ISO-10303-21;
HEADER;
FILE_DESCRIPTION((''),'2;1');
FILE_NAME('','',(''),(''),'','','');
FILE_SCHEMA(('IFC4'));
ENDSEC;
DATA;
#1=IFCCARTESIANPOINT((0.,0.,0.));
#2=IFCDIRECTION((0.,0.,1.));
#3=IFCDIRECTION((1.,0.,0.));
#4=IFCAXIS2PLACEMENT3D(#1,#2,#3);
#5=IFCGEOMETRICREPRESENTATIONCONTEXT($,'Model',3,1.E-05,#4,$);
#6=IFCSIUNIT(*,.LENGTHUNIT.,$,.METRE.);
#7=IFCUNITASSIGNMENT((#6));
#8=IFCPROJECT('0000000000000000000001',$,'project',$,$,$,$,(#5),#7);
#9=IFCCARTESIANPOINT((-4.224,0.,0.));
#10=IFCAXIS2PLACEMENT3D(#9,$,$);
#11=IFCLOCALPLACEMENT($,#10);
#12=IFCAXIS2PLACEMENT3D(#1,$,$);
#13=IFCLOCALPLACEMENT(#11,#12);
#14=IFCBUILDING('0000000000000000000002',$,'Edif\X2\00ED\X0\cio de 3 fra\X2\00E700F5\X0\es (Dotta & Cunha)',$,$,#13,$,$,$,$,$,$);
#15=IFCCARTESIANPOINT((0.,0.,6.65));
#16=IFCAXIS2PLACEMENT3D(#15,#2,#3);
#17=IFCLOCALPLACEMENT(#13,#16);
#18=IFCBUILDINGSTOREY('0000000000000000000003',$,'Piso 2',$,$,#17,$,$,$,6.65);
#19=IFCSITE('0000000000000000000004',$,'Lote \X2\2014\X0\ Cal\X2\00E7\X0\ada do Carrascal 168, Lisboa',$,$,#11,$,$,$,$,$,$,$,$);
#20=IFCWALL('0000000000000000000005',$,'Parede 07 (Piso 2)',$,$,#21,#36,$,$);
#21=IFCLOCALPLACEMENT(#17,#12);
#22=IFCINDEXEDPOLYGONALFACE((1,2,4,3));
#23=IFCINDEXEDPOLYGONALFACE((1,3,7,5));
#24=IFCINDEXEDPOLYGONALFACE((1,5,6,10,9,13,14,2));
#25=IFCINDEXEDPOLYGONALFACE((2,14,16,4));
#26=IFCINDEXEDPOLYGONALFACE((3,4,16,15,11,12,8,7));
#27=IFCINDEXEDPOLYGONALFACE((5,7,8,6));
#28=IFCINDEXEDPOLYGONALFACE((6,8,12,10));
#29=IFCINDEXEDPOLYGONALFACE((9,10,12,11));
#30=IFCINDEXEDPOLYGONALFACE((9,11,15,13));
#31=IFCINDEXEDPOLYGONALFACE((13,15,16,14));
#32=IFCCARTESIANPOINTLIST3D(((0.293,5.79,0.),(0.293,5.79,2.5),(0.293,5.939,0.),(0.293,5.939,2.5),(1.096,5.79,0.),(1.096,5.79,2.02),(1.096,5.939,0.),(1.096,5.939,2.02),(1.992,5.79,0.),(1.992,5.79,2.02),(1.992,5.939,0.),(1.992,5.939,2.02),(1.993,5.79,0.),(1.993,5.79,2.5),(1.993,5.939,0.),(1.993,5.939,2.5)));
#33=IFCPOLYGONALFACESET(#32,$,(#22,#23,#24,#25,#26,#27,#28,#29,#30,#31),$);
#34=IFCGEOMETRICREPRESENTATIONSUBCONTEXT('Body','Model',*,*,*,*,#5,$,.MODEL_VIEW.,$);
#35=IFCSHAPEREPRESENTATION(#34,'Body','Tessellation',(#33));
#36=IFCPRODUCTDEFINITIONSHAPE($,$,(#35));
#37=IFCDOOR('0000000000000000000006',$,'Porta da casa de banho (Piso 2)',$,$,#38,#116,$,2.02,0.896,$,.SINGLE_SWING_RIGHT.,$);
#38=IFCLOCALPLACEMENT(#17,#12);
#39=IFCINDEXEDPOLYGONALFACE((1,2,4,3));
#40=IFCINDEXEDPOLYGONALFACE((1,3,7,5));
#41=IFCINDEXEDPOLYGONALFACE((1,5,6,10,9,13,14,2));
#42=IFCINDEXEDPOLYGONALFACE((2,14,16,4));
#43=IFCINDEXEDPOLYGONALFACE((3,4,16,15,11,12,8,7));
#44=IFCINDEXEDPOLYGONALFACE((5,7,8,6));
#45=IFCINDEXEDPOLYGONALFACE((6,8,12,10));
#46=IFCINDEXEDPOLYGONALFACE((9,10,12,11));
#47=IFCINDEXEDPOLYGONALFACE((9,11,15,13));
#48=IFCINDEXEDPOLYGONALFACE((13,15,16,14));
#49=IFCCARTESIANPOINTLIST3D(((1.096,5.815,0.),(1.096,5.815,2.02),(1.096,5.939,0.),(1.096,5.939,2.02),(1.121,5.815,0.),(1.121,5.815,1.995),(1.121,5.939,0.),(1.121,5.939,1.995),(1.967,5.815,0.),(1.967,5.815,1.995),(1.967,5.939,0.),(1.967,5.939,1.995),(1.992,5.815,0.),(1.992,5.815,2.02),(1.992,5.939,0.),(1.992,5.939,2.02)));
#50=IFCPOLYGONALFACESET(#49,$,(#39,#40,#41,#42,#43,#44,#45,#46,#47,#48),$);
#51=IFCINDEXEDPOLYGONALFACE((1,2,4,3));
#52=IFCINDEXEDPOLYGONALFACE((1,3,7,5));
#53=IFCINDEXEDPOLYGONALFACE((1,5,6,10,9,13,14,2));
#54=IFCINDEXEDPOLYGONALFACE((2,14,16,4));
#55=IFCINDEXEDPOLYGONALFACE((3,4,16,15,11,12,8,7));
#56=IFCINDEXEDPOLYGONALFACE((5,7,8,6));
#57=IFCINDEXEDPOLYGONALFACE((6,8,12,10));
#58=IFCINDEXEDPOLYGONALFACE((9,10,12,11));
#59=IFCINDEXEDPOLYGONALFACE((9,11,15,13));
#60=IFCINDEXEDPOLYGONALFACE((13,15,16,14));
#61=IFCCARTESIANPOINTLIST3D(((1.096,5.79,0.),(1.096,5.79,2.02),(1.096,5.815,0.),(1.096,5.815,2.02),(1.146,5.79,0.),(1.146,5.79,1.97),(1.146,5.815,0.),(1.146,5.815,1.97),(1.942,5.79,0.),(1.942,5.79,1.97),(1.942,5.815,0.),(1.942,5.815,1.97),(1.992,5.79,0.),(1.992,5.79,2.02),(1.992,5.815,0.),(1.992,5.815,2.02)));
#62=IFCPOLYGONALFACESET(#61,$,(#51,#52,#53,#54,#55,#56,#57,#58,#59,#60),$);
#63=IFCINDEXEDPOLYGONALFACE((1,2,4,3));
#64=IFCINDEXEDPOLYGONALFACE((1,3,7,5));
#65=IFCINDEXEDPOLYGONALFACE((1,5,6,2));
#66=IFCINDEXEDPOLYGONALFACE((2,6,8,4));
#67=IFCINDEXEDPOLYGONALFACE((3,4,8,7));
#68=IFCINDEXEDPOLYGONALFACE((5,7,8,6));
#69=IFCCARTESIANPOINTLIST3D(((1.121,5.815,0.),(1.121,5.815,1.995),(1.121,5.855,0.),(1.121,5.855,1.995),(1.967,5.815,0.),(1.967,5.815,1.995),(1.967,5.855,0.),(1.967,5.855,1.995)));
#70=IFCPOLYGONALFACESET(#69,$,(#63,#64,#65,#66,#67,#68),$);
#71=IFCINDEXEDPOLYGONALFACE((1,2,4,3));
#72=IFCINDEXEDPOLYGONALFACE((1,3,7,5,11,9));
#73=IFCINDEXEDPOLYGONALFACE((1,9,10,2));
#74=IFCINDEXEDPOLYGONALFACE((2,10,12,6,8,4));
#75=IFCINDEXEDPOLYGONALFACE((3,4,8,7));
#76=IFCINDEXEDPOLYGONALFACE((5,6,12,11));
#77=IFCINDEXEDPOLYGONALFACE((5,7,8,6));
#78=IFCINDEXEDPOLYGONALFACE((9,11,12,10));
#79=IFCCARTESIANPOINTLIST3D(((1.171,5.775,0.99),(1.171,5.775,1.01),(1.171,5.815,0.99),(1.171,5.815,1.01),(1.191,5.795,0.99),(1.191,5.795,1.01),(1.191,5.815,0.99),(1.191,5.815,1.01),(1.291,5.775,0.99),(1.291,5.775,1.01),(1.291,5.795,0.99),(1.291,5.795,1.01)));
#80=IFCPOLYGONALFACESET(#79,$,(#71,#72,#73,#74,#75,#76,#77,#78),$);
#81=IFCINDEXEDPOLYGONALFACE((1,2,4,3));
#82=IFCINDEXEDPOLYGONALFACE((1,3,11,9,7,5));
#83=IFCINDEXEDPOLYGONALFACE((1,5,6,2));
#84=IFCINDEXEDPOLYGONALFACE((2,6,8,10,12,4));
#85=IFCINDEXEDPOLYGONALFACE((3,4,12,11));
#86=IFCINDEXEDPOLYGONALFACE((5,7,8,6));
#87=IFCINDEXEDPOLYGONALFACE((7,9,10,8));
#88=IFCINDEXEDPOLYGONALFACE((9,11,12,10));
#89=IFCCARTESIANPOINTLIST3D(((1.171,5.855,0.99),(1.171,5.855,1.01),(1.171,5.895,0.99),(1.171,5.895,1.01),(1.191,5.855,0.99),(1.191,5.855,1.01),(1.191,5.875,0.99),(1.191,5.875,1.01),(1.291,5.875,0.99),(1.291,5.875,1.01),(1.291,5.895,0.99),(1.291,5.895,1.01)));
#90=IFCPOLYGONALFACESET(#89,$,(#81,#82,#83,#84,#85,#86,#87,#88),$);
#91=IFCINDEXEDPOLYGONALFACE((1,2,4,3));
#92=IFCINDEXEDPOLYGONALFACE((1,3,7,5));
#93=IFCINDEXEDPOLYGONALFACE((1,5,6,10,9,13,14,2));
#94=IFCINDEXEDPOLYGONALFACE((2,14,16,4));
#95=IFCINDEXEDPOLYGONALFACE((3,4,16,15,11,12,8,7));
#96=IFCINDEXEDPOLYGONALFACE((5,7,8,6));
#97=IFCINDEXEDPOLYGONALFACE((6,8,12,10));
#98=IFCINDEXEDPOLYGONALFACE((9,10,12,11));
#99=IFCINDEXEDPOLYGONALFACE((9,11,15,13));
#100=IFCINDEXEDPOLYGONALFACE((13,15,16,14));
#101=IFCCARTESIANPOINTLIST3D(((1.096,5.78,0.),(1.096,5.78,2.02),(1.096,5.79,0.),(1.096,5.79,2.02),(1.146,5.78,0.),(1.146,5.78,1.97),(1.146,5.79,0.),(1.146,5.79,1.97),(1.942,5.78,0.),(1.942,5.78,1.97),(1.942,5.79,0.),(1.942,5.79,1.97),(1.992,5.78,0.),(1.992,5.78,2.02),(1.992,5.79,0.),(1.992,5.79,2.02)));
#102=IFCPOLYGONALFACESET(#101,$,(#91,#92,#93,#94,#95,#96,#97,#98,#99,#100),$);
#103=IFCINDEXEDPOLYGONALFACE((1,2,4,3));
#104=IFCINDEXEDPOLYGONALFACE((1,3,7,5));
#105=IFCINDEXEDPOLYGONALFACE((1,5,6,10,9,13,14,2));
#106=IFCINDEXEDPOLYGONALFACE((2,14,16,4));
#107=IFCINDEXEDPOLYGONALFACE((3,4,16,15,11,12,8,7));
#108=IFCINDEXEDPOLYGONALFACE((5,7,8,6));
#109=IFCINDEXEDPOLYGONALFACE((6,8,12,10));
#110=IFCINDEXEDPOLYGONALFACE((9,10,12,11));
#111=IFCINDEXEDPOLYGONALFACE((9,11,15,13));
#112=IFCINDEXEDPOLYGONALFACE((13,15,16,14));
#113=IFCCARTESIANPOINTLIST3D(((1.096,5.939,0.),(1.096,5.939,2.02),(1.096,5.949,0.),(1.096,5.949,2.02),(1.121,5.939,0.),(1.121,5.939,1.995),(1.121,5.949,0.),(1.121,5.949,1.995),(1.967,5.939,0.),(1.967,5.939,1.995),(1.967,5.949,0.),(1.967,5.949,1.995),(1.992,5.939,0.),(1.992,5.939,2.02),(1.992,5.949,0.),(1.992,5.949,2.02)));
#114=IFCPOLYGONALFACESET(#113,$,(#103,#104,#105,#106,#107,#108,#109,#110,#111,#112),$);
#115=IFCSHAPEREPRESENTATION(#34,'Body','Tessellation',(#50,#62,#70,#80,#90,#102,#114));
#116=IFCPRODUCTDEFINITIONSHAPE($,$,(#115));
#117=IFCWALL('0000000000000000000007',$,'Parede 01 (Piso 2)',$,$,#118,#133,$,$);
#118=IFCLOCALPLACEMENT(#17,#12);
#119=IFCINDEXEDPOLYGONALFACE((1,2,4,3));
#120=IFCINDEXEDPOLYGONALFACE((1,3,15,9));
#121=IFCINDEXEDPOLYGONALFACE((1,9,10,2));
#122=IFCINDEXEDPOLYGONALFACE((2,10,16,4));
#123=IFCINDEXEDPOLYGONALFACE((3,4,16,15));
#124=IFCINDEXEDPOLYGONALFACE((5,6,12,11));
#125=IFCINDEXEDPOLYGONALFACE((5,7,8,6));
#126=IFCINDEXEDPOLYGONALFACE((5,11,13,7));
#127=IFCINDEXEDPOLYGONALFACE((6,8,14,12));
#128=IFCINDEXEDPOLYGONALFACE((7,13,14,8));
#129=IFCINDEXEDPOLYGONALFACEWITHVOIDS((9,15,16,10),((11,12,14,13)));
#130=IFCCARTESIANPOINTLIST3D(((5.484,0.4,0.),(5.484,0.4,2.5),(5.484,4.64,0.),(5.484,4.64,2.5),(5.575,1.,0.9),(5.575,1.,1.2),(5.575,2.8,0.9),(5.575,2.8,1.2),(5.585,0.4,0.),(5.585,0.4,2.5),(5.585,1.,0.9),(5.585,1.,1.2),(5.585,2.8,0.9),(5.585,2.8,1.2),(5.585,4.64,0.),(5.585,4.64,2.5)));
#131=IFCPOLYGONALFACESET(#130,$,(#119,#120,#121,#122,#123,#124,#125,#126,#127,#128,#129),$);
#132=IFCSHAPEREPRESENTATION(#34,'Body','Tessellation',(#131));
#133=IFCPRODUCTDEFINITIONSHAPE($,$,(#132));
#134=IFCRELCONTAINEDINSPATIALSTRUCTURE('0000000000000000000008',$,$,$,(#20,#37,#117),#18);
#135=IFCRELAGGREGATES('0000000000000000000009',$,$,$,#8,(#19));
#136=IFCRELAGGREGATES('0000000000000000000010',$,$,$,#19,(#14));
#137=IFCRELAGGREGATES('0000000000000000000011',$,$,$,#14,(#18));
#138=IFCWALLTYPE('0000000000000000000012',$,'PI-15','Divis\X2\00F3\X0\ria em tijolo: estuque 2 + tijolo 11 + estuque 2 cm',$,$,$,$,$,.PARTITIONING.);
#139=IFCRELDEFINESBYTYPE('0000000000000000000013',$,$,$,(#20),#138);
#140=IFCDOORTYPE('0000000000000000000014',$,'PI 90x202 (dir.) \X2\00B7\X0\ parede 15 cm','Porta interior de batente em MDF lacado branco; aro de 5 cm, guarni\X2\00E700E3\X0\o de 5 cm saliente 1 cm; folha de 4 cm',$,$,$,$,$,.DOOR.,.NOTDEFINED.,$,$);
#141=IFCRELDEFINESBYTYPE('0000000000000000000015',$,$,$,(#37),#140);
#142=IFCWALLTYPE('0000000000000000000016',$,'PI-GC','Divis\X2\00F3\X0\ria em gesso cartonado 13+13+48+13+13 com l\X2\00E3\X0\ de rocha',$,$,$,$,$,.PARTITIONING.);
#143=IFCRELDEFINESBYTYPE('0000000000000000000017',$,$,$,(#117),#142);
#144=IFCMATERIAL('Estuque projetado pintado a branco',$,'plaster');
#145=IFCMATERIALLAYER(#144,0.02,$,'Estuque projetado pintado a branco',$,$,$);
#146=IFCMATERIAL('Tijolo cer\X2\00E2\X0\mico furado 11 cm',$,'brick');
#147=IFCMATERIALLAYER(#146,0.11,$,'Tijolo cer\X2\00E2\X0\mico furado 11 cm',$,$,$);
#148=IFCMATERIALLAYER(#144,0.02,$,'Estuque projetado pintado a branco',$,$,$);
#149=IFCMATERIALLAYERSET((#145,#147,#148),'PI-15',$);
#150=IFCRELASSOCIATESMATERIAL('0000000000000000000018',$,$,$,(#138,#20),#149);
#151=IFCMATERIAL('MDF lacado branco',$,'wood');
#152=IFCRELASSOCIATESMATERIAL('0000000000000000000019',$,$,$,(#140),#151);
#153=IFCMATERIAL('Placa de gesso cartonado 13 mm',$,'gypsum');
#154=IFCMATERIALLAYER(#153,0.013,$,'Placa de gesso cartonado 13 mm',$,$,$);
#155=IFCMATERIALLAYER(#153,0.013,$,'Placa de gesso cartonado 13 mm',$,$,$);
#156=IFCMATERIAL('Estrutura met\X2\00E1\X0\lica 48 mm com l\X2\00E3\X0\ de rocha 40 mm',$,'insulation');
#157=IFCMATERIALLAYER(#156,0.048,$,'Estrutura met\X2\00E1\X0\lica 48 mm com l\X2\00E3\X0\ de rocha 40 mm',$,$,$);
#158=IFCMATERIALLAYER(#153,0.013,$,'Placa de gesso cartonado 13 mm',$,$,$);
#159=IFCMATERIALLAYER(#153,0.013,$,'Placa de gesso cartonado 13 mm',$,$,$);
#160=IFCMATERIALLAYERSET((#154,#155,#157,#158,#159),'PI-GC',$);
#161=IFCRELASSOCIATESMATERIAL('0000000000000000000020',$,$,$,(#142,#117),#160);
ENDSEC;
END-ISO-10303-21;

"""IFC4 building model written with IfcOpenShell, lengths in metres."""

from ifc_helpers import new_model, si_unit, frame, origin, origin_with_axes, place, context, subcontext, project, spatial, line, indexed_curve, outline, extrude, source, transform, mapped, material, layer, layer_set, layer_usage, type_object, type_shapes, element, fill, save


model = new_model("IFC4")

# Units and contexts
model_context = context("Model", 3, precision=1e-05, world=origin_with_axes())
body_context = subcontext(model_context, "Body", "Model", "MODEL_VIEW")
ifc_project = project(units=[si_unit("LENGTHUNIT", "METRE")], contexts=[model_context])

# Site, building, storey
site_placement = place(None, frame((-4.224, 0.0, 0.0)))
site = spatial("IfcSite", under=ifc_project, at=site_placement, Name="Lote — Calçada do Carrascal 168, Lisboa")
building_placement = place(site_placement, origin())
building = spatial("IfcBuilding", under=site, at=building_placement, Name="Edifício de 3 frações (Dotta & Cunha)")
storey_placement = place(building_placement, frame((0.0, 0.0, 6.65), z_axis=(0.0, 0.0, 1.0), x_axis=(1.0, 0.0, 0.0)))
storey = spatial("IfcBuildingStorey", under=building, at=storey_placement, Name="Piso 2", Elevation=6.65)

# Shared definitions
ifc_material_1 = material(Name="Estuque projetado pintado a branco", Category="plaster")
ifc_layer_1 = layer(ifc_material_1, 0.02, Name="Estuque projetado pintado a branco")
ifc_material_2 = material(Name="Tijolo cerâmico furado 11 cm", Category="brick")
ifc_layer_2 = layer(ifc_material_2, 0.11, Name="Tijolo cerâmico furado 11 cm")
ifc_layer_3 = layer(ifc_material_1, 0.02, Name="Estuque projetado pintado a branco")
ifc_layer_set_1 = layer_set([ifc_layer_1, ifc_layer_2, ifc_layer_3], Name="PI-15")
wall_type_1 = type_object("IfcWallType", Name="PI-15", Description="Divisória em tijolo: estuque 2 + tijolo 11 + estuque 2 cm", PredefinedType="PARTITIONING", material=ifc_layer_set_1)

# Shared definitions
ifc_material_3 = material(Name="MDF lacado branco", Category="wood")

# Wall, opening, door
ifc_layer_usage_1 = layer_usage(ifc_layer_set_1, "AXIS2", "POSITIVE", 0.0)
wall_1_placement = place(storey_placement, origin_with_axes())
wall_1 = element("IfcWall", 1, at=wall_1_placement, inside=storey, type_object=wall_type_1, material=ifc_layer_usage_1, Name="Parede 07 (Piso 2)", context=body_context, shape_type="SweptSolid", body=[
    extrude(outline(indexed_curve([(1.993, 5.79), (1.993, 5.939), (0.293, 5.939), (0.293, 5.79)], segments=[line(1, 2, 3, 4, 1)])), origin_with_axes(), (0.0, 0.0, 1.0), 2.5),
])
opening_1_placement = place(wall_1_placement, origin_with_axes())
opening_1 = element("IfcOpeningElement", 2, at=opening_1_placement, cuts=wall_1, context=body_context, shape_type="SweptSolid", body=[
    extrude(outline(indexed_curve([(1.992, 5.788), (1.992, 5.941), (1.096, 5.941), (1.096, 5.788)], segments=[line(1, 2, 3, 4, 1)])), origin_with_axes(), (0.0, 0.0, 1.0), 2.02),
])
door_type_1 = type_object("IfcDoorType", Name="PI 90x202 (dir.) · parede 15 cm", Description="Porta interior de batente em MDF lacado branco; aro de 5 cm, guarnição de 5 cm saliente 1 cm; folha de 4 cm", OperationType="NOTDEFINED", PredefinedType="DOOR", material=ifc_material_3)
shared_shape_1 = source(origin_with_axes(), body_context, "Body", "SweptSolid", [
    extrude(outline(indexed_curve([(0.0, 0.0), (0.0, 2.02), (0.896, 2.02), (0.896, 0.0), (0.871, 0.0), (0.871, 1.995), (0.025, 1.995), (0.025, 0.0)], segments=[line(1, 2, 3, 4, 5, 6, 7, 8, 1)])), frame((0.0, 0.025, 0.0), z_axis=(0.0, -1.0, 0.0), x_axis=(1.0, 0.0, 0.0)), (0.0, 0.0, -1.0), 0.124),
    extrude(outline(indexed_curve([(0.0, 0.0), (0.0, 2.02), (0.896, 2.02), (0.896, 0.0), (0.846, 0.0), (0.846, 1.97), (0.05, 1.97), (0.05, 0.0)], segments=[line(1, 2, 3, 4, 5, 6, 7, 8, 1)])), frame((0.0, 0.0, 0.0), z_axis=(0.0, -1.0, 0.0), x_axis=(1.0, 0.0, 0.0)), (0.0, 0.0, -1.0), 0.025),
    extrude(outline(indexed_curve([(0.0, 0.0), (0.846, 0.0), (0.846, 0.04), (0.0, 0.04)], segments=[line(1, 2, 3, 4, 1)])), frame((0.025, 0.025, 0.0), z_axis=(0.0, 0.0, 1.0), x_axis=(1.0, 0.0, 0.0)), (0.0, 0.0, 1.0), 1.995),
    extrude(outline(indexed_curve([(0.0, 0.0), (0.0, -0.04), (0.12, -0.04), (0.12, -0.02), (0.02, -0.02), (0.02, 0.0)], segments=[line(1, 2, 3, 4, 5, 6, 1)])), frame((0.075, 0.025, 0.99), z_axis=(0.0, 0.0, 1.0), x_axis=(1.0, 0.0, 0.0)), (0.0, 0.0, 1.0), 0.02),
    extrude(outline(indexed_curve([(0.0, 0.0), (0.0, 0.04), (0.12, 0.04), (0.12, 0.02), (0.02, 0.02), (0.02, 0.0)], segments=[line(1, 2, 3, 4, 5, 6, 1)])), frame((0.075, 0.065, 0.99), z_axis=(0.0, 0.0, 1.0), x_axis=(1.0, 0.0, 0.0)), (0.0, 0.0, 1.0), 0.02),
    extrude(outline(indexed_curve([(0.0, 0.0), (0.0, 2.02), (0.896, 2.02), (0.896, 0.0), (0.846, 0.0), (0.846, 1.97), (0.05, 1.97), (0.05, 0.0)], segments=[line(1, 2, 3, 4, 5, 6, 7, 8, 1)])), frame((0.0, -0.01, 0.0), z_axis=(0.0, -1.0, 0.0), x_axis=(1.0, 0.0, 0.0)), (0.0, 0.0, -1.0), 0.01),
    extrude(outline(indexed_curve([(0.0, 0.0), (0.0, 2.02), (0.896, 2.02), (0.896, 0.0), (0.871, 0.0), (0.871, 1.995), (0.025, 1.995), (0.025, 0.0)], segments=[line(1, 2, 3, 4, 5, 6, 7, 8, 1)])), frame((0.0, 0.149, 0.0), z_axis=(0.0, -1.0, 0.0), x_axis=(1.0, 0.0, 0.0)), (0.0, 0.0, -1.0), 0.01),
])
type_shapes(door_type_1, [shared_shape_1])
door_1_placement = place(storey_placement, frame((1.096, 5.79, 0.0), z_axis=(0.0, 0.0, 1.0), x_axis=(1.0, 0.0, 0.0)))
door_1 = element("IfcDoor", 3, at=door_1_placement, inside=storey, type_object=door_type_1, Name="Porta da casa de banho (Piso 2)", OperationType="SINGLE_SWING_RIGHT", OverallHeight=2.02, OverallWidth=0.896, context=body_context, shape_type="MappedRepresentation", body=[
    mapped(shared_shape_1, transform((0.0, 0.0, 0.0), x_axis=(1.0, 0.0, 0.0), y_axis=(0.0, 1.0, 0.0), z_axis=(0.0, 0.0, 1.0), scale=1.0)),
])
fill(opening_1, door_1)

# Wall, opening
ifc_material_4 = material(Name="Placa de gesso cartonado 13 mm", Category="gypsum")
ifc_layer_4 = layer(ifc_material_4, 0.013, Name="Placa de gesso cartonado 13 mm")
ifc_layer_5 = layer(ifc_material_4, 0.013, Name="Placa de gesso cartonado 13 mm")
ifc_material_5 = material(Name="Estrutura metálica 48 mm com lã de rocha 40 mm", Category="insulation")
ifc_layer_6 = layer(ifc_material_5, 0.048, Name="Estrutura metálica 48 mm com lã de rocha 40 mm")
ifc_layer_7 = layer(ifc_material_4, 0.013, Name="Placa de gesso cartonado 13 mm")
ifc_layer_8 = layer(ifc_material_4, 0.013, Name="Placa de gesso cartonado 13 mm")
ifc_layer_set_2 = layer_set([ifc_layer_4, ifc_layer_5, ifc_layer_6, ifc_layer_7, ifc_layer_8], Name="PI-GC")
ifc_layer_usage_2 = layer_usage(ifc_layer_set_2, "AXIS2", "POSITIVE", 0.0)
wall_type_2 = type_object("IfcWallType", Name="PI-GC", Description="Divisória em gesso cartonado 13+13+48+13+13 com lã de rocha", PredefinedType="PARTITIONING", material=ifc_layer_set_2)
wall_2_placement = place(storey_placement, origin_with_axes())
wall_2 = element("IfcWall", 4, at=wall_2_placement, inside=storey, type_object=wall_type_2, material=ifc_layer_usage_2, Name="Parede 01 (Piso 2)", context=body_context, shape_type="SweptSolid", body=[
    extrude(outline(indexed_curve([(5.585, 0.4), (5.585, 4.64), (5.484, 4.64), (5.484, 0.4)], segments=[line(1, 2, 3, 4, 1)])), origin_with_axes(), (0.0, 0.0, 1.0), 2.5),
])
opening_2_placement = place(wall_2_placement, frame((0.0, 0.0, 0.9), z_axis=(0.0, 0.0, 1.0), x_axis=(1.0, 0.0, 0.0)))
element("IfcOpeningElement", 5, at=opening_2_placement, cuts=wall_2, PredefinedType="RECESS", context=body_context, shape_type="SweptSolid", body=[
    extrude(outline(indexed_curve([(5.59, 1.0), (5.59, 2.8), (5.575, 2.8), (5.575, 1.0)], segments=[line(1, 2, 3, 4, 1)])), origin_with_axes(), (0.0, 0.0, 1.0), 0.3),
])

save(model, "model.ifc")
